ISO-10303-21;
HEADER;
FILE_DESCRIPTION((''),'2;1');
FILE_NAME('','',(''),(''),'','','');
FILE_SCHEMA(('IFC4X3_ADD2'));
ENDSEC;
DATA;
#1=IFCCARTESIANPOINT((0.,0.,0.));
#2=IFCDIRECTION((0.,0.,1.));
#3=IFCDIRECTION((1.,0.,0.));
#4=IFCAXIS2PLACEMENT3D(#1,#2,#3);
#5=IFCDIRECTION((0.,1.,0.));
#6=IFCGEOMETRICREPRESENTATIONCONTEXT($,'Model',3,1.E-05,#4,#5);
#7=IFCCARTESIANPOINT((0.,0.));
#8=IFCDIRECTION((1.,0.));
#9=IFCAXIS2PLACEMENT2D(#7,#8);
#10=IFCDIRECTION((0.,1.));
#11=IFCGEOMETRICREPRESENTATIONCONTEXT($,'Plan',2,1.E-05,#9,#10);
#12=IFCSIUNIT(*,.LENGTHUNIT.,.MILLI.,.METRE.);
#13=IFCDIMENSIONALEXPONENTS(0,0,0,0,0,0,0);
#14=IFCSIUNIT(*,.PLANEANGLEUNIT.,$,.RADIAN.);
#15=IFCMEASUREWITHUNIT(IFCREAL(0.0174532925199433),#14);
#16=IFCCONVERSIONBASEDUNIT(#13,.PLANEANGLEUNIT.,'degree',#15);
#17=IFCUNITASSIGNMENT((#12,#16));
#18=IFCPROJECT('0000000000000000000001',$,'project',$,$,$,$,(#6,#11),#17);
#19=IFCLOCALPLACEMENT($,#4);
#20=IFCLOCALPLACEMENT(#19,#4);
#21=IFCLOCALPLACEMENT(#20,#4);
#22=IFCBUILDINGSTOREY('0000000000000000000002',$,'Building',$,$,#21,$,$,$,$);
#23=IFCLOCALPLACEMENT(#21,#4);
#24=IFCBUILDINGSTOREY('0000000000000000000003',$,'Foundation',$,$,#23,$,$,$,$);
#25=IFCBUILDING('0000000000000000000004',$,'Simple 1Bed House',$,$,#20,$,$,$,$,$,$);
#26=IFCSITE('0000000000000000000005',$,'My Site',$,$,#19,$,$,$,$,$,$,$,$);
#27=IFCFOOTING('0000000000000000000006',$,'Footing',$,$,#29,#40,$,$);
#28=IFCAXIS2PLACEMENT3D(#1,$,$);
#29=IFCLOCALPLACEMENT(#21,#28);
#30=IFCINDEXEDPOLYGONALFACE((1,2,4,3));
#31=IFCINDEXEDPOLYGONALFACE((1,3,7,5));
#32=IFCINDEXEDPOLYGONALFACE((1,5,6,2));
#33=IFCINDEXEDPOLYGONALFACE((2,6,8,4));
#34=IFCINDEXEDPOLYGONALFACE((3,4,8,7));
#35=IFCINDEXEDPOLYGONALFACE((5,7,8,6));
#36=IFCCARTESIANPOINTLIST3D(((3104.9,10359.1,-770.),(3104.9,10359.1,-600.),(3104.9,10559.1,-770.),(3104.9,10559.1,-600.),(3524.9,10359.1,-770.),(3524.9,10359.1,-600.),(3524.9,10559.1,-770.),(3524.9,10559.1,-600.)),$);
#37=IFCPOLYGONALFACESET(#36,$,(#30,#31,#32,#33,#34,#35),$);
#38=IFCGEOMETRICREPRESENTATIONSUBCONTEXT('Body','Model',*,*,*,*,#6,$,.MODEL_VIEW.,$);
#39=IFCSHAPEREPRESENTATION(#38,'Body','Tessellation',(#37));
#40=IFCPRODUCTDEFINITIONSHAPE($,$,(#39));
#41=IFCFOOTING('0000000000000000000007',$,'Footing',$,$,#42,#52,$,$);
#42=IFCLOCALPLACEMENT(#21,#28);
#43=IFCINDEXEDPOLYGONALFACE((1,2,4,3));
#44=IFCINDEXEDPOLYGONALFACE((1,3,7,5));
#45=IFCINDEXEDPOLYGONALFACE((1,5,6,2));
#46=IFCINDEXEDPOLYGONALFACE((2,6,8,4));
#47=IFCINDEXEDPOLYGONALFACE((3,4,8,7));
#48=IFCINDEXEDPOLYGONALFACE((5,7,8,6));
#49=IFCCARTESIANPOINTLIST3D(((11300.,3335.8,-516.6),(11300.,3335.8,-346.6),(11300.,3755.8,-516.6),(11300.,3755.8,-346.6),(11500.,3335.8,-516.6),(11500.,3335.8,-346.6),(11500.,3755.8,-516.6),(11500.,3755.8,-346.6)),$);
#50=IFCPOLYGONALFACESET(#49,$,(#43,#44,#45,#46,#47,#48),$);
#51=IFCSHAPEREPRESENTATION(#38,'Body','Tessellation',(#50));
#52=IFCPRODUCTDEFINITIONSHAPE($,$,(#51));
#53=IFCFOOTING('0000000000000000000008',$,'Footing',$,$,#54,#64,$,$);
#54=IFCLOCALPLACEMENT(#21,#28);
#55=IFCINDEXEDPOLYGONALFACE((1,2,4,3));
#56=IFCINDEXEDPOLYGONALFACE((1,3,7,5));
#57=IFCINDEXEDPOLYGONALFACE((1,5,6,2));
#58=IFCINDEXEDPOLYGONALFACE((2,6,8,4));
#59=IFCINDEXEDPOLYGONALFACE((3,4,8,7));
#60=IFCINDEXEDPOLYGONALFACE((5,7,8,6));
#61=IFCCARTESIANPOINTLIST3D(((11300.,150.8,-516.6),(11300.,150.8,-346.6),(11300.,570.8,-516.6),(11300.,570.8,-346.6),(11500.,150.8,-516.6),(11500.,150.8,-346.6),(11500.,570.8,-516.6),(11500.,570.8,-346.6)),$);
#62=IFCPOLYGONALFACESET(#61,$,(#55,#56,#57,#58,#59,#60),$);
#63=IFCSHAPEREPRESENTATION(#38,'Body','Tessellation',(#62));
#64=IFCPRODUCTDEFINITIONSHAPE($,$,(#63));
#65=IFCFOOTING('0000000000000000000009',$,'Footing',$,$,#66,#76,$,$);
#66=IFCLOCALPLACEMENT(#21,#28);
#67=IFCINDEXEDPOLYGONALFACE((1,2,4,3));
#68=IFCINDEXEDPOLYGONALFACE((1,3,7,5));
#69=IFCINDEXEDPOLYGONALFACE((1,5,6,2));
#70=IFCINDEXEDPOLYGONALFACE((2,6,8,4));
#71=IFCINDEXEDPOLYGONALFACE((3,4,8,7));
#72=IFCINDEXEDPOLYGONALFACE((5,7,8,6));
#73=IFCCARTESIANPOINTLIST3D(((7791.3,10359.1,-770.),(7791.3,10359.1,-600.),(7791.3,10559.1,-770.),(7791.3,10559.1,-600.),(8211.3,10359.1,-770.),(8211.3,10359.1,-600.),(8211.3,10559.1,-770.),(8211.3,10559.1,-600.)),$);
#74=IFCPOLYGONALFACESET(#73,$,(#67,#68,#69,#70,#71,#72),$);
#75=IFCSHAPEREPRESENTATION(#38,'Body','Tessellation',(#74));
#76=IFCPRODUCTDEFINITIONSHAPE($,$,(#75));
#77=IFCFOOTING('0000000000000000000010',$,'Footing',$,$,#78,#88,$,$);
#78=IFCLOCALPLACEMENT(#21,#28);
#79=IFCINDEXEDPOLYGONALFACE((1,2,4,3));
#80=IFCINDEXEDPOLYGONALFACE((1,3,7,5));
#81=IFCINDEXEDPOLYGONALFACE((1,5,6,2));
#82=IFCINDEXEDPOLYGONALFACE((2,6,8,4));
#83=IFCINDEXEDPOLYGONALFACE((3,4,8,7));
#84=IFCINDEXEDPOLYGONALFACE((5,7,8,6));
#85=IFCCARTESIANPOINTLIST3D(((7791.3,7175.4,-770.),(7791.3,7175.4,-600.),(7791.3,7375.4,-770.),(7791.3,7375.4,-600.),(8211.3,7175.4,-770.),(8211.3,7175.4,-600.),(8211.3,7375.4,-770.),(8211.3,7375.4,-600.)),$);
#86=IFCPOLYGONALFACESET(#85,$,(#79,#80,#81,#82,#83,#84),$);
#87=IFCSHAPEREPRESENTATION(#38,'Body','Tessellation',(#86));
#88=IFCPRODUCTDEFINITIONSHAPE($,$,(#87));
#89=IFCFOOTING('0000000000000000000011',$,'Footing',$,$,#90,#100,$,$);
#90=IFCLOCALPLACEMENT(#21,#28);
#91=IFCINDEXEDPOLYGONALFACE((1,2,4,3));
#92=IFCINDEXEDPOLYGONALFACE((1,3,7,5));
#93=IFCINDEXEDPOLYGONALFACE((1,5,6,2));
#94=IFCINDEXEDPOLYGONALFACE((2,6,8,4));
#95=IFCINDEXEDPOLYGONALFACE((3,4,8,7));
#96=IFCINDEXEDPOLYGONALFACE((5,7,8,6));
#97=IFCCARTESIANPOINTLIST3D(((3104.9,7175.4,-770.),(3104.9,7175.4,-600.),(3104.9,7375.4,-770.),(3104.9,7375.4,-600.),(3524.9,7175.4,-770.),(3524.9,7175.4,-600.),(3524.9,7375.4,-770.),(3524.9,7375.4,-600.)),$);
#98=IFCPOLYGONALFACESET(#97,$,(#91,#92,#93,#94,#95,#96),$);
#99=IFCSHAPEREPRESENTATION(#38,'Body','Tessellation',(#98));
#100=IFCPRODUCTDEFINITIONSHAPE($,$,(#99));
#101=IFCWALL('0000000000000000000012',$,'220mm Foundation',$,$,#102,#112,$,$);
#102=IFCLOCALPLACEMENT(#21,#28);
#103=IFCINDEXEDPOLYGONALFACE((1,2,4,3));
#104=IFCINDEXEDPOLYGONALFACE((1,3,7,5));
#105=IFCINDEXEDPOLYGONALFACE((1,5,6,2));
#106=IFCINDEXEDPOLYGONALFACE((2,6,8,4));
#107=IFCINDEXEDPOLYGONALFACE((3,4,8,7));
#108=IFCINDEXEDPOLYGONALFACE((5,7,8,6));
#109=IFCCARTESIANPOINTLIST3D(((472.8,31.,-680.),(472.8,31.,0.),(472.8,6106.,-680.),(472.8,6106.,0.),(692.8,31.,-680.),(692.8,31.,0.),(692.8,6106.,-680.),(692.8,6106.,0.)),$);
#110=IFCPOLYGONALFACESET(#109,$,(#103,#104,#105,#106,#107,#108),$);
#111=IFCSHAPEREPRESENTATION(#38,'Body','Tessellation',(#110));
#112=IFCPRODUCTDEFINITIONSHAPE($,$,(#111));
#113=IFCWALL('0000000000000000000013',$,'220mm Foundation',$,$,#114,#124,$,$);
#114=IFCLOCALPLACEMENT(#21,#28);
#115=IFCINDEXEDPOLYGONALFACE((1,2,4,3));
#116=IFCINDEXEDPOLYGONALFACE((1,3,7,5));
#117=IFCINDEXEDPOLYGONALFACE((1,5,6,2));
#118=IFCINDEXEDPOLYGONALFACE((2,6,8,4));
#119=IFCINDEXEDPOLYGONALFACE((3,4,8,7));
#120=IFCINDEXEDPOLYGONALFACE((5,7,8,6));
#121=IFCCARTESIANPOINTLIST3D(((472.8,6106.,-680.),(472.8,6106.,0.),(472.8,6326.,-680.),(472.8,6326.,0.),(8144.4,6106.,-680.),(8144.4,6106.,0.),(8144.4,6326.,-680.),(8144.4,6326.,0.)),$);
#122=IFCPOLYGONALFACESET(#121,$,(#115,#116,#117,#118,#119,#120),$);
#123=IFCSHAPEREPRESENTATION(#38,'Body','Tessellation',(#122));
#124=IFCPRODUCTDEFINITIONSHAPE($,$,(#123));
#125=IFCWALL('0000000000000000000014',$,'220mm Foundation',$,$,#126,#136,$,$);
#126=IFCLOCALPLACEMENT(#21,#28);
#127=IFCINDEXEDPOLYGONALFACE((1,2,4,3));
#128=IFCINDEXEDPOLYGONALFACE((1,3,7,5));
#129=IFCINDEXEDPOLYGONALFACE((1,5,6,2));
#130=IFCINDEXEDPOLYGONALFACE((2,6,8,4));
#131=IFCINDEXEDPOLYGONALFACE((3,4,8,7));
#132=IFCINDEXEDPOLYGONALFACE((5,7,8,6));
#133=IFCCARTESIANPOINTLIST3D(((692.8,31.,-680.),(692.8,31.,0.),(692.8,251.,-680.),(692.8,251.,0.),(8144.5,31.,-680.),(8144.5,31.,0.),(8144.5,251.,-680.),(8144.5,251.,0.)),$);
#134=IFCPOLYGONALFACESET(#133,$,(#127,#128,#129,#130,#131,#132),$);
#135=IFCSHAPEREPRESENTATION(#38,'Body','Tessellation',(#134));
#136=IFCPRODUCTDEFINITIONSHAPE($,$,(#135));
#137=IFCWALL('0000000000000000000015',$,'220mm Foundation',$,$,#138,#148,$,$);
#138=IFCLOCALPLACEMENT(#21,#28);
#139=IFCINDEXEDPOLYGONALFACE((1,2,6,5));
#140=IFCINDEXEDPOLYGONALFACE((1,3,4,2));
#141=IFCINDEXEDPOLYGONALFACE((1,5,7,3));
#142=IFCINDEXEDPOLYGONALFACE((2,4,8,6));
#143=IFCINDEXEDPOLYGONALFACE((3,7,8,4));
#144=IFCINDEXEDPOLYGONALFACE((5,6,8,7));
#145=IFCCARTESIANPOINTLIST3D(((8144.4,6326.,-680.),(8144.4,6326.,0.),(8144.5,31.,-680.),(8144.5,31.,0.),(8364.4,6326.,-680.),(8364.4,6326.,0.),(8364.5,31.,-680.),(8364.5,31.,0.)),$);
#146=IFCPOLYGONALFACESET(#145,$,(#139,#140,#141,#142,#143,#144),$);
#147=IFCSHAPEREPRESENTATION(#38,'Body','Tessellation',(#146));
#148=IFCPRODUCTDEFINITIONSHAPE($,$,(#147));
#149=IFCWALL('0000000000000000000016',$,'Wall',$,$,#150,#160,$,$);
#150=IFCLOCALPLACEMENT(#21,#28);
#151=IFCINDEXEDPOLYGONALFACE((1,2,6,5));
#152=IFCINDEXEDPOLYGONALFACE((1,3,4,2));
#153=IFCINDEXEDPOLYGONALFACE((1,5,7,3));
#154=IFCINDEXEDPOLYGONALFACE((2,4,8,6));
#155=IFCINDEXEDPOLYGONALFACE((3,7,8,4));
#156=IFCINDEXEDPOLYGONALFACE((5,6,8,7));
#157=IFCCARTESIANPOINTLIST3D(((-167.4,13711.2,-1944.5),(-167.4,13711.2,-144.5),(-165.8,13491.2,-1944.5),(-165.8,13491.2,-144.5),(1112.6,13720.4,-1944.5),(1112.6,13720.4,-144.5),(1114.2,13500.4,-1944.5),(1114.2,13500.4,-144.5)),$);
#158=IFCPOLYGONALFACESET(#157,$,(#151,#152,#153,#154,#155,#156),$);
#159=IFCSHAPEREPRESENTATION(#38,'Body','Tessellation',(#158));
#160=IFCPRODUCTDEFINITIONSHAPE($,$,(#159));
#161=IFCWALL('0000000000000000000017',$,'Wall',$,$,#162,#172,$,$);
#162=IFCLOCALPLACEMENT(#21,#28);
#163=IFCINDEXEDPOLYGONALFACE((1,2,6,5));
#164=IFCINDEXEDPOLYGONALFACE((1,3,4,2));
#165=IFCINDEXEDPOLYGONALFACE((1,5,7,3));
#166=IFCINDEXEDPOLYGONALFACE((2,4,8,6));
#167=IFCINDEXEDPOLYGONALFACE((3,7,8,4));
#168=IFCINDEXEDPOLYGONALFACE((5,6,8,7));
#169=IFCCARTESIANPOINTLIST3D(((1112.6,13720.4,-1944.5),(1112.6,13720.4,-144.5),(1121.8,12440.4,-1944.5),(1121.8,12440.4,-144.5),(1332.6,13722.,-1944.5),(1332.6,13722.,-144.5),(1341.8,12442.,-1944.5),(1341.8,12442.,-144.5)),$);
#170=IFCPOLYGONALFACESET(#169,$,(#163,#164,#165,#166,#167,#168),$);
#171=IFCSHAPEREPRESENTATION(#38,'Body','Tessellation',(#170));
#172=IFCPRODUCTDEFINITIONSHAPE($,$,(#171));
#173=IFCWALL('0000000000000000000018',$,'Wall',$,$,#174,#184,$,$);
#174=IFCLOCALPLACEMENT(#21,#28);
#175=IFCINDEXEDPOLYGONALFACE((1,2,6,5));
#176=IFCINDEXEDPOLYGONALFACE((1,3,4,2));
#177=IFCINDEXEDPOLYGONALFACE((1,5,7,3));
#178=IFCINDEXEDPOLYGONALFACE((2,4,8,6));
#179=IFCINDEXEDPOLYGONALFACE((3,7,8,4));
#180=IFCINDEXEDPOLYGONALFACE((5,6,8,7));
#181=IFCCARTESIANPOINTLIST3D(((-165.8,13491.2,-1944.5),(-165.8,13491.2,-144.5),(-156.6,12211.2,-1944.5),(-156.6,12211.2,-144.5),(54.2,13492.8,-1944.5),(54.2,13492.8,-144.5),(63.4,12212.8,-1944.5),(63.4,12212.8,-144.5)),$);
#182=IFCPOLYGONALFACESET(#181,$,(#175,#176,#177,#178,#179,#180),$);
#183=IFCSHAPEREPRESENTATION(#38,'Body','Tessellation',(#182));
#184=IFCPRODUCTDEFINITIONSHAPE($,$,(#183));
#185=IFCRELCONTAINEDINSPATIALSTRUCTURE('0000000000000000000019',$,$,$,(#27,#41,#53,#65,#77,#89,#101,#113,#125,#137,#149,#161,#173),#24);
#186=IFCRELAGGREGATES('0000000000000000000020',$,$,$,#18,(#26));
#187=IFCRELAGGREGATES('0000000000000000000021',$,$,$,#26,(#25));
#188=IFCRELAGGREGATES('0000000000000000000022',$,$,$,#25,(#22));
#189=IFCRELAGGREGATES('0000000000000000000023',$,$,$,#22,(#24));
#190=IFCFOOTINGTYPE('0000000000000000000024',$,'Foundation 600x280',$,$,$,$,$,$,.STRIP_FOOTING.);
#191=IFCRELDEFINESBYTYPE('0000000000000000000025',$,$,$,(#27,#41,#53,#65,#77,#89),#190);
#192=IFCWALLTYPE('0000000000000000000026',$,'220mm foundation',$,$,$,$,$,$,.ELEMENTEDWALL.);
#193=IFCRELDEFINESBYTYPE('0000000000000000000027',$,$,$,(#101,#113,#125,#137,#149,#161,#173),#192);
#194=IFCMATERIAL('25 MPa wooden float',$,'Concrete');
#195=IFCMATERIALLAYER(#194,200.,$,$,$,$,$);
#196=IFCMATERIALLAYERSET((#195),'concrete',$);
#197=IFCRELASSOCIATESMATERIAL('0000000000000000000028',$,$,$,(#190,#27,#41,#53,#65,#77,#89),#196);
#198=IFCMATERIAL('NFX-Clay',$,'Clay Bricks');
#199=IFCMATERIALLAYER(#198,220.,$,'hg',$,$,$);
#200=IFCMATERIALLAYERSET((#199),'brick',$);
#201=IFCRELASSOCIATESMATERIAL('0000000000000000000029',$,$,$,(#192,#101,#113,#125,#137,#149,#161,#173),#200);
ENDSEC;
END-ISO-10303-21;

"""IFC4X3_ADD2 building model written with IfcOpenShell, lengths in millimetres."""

from ifc_helpers import new_model, entity, si_unit, converted_unit, direction, frame, origin_with_axes, origin_2d_with_axis, place, context, subcontext, project, spatial, indexed_curve, outline, extrude, material, layer, layer_set, layer_usage, type_object, element, save


model = new_model("IFC4X3_ADD2")

# Units and contexts
model_context = context("Model", 3, precision=1e-05, world=origin_with_axes(), true_north=direction((0.0, 1.0, 0.0)))
plan_context = context("Plan", 2, precision=1e-05, world=origin_2d_with_axis(), true_north=direction((0.0, 1.0)))
body_context = subcontext(model_context, "Body", "Model", "MODEL_VIEW")
ifc_project = project(units=[si_unit("LENGTHUNIT", "METRE", prefix="MILLI"), converted_unit("PLANEANGLEUNIT", "degree", entity("IfcReal", 0.0174532925199433), si_unit("PLANEANGLEUNIT", "RADIAN"), dimensions=[0, 0, 0, 0, 0, 0, 0])], contexts=[model_context, plan_context])

# Site, building, storeys
site_placement = place(None, origin_with_axes())
site = spatial("IfcSite", under=ifc_project, at=site_placement, Name="My Site")
building_placement = place(site_placement, origin_with_axes())
building = spatial("IfcBuilding", under=site, at=building_placement, Name="Simple 1Bed House")
storey_1_placement = place(building_placement, origin_with_axes())
storey_1 = spatial("IfcBuildingStorey", under=building, at=storey_1_placement, Name="Building")
storey_2_placement = place(storey_1_placement, origin_with_axes())
storey_2 = spatial("IfcBuildingStorey", under=storey_1, at=storey_2_placement, Name="Foundation")

# Footings
ifc_material_1 = material(Name="25 MPa wooden float", Category="Concrete")
ifc_layer_1 = layer(ifc_material_1, 200.0)
ifc_layer_set_1 = layer_set([ifc_layer_1], Name="concrete")
footing_type = type_object("IfcFootingType", Name="Foundation 600x280", PredefinedType="STRIP_FOOTING", material=ifc_layer_set_1)
ifc_layer_usage_1 = layer_usage(ifc_layer_set_1, "AXIS2", "POSITIVE", 0.0)
footing_1_placement = place(storey_2_placement, frame((3104.9, 10359.1, -770.0), z_axis=(0.0, 0.0, 1.0), x_axis=(1.0, 0.0, 0.0)))
element("IfcFooting", 1, at=footing_1_placement, inside=storey_2, type_object=footing_type, material=ifc_layer_usage_1, Name="Footing", context=body_context, shape_type="SweptSolid", body=[
    extrude(outline(indexed_curve([(0.0, 0.0), (0.0, 200.0), (420.0, 200.0), (420.0, 0.0), (0.0, 0.0)], self_intersect=False)), origin_with_axes(), (0.0, 0.0, 1.0), 170.0),
])
ifc_layer_usage_2 = layer_usage(ifc_layer_set_1, "AXIS2", "POSITIVE", 0.0)
footing_2_placement = place(storey_2_placement, frame((11500.0, 3335.8, -516.6), z_axis=(0.0, 0.0, 1.0), x_axis=(0.0, 1.0, 0.0)))
element("IfcFooting", 2, at=footing_2_placement, inside=storey_2, type_object=footing_type, material=ifc_layer_usage_2, Name="Footing", context=body_context, shape_type="SweptSolid", body=[
    extrude(outline(indexed_curve([(0.0, 0.0), (0.0, 200.0), (420.0, 200.0), (420.0, 0.0), (0.0, 0.0)], self_intersect=False)), origin_with_axes(), (0.0, 0.0, 1.0), 170.0),
])
ifc_layer_usage_3 = layer_usage(ifc_layer_set_1, "AXIS2", "POSITIVE", 0.0)
footing_3_placement = place(storey_2_placement, frame((11500.0, 150.8, -516.6), z_axis=(0.0, 0.0, 1.0), x_axis=(0.0, 1.0, 0.0)))
element("IfcFooting", 3, at=footing_3_placement, inside=storey_2, type_object=footing_type, material=ifc_layer_usage_3, Name="Footing", context=body_context, shape_type="SweptSolid", body=[
    extrude(outline(indexed_curve([(0.0, 0.0), (0.0, 200.0), (420.0, 200.0), (420.0, 0.0), (0.0, 0.0)], self_intersect=False)), origin_with_axes(), (0.0, 0.0, 1.0), 170.0),
])
ifc_layer_usage_4 = layer_usage(ifc_layer_set_1, "AXIS2", "POSITIVE", 0.0)
footing_4_placement = place(storey_2_placement, frame((7791.3, 10359.1, -770.0), z_axis=(0.0, 0.0, 1.0), x_axis=(1.0, 0.0, 0.0)))
element("IfcFooting", 4, at=footing_4_placement, inside=storey_2, type_object=footing_type, material=ifc_layer_usage_4, Name="Footing", context=body_context, shape_type="SweptSolid", body=[
    extrude(outline(indexed_curve([(0.0, 0.0), (0.0, 200.0), (420.0, 200.0), (420.0, 0.0), (0.0, 0.0)], self_intersect=False)), origin_with_axes(), (0.0, 0.0, 1.0), 170.0),
])
ifc_layer_usage_5 = layer_usage(ifc_layer_set_1, "AXIS2", "POSITIVE", 0.0)
footing_5_placement = place(storey_2_placement, frame((7791.3, 7175.4, -770.0), z_axis=(0.0, 0.0, 1.0), x_axis=(1.0, 0.0, 0.0)))
element("IfcFooting", 5, at=footing_5_placement, inside=storey_2, type_object=footing_type, material=ifc_layer_usage_5, Name="Footing", context=body_context, shape_type="SweptSolid", body=[
    extrude(outline(indexed_curve([(0.0, 0.0), (0.0, 200.0), (420.0, 200.0), (420.0, 0.0), (0.0, 0.0)], self_intersect=False)), origin_with_axes(), (0.0, 0.0, 1.0), 170.0),
])
ifc_layer_usage_6 = layer_usage(ifc_layer_set_1, "AXIS2", "POSITIVE", 0.0)
footing_6_placement = place(storey_2_placement, frame((3104.9, 7175.4, -770.0), z_axis=(0.0, 0.0, 1.0), x_axis=(1.0, 0.0, 0.0)))
element("IfcFooting", 6, at=footing_6_placement, inside=storey_2, type_object=footing_type, material=ifc_layer_usage_6, Name="Footing", context=body_context, shape_type="SweptSolid", body=[
    extrude(outline(indexed_curve([(0.0, 0.0), (0.0, 200.0), (420.0, 200.0), (420.0, 0.0), (0.0, 0.0)], self_intersect=False)), origin_with_axes(), (0.0, 0.0, 1.0), 170.0),
])

# Walls
ifc_material_2 = material(Name="NFX-Clay", Category="Clay Bricks")
ifc_layer_2 = layer(ifc_material_2, 220.0, Name="hg")
ifc_layer_set_2 = layer_set([ifc_layer_2], Name="brick")
ifc_layer_usage_7 = layer_usage(ifc_layer_set_2, "AXIS2", "POSITIVE", 0.0)
wall_type = type_object("IfcWallType", Name="220mm foundation", PredefinedType="ELEMENTEDWALL", material=ifc_layer_set_2)
wall_1_placement = place(storey_2_placement, frame((472.8, 6106.0, -680.0), z_axis=(0.0, 0.0, 1.0), x_axis=(0.000002, -1.0, 0.0)))
element("IfcWall", 7, at=wall_1_placement, inside=storey_2, type_object=wall_type, material=ifc_layer_usage_7, Name="220mm Foundation", context=body_context, shape_type="SweptSolid", body=[
    extrude(outline(indexed_curve([(0.0, 0.0), (0.0, 220.0), (6075.0, 220.0), (6075.0, 0.0), (0.0, 0.0)], self_intersect=False)), origin_with_axes(), (0.0, 0.0, 1.0), 680.0),
])
ifc_layer_usage_8 = layer_usage(ifc_layer_set_2, "AXIS2", "POSITIVE", 0.0)
wall_2_placement = place(storey_2_placement, frame((472.8, 6106.0, -680.0), z_axis=(0.0, 0.0, 1.0), x_axis=(1.0, 0.000001, 0.0)))
element("IfcWall", 8, at=wall_2_placement, inside=storey_2, type_object=wall_type, material=ifc_layer_usage_8, Name="220mm Foundation", context=body_context, shape_type="SweptSolid", body=[
    extrude(outline(indexed_curve([(0.0, 0.0), (0.0, 220.0), (7671.6, 220.0), (7671.6, 0.0), (0.0, 0.0)], self_intersect=False)), origin_with_axes(), (0.0, 0.0, 1.0), 680.0),
])
ifc_layer_usage_9 = layer_usage(ifc_layer_set_2, "AXIS2", "POSITIVE", 0.0)
wall_3_placement = place(storey_2_placement, frame((692.8, 31.0, -680.0), z_axis=(0.0, 0.0, 1.0), x_axis=(1.0, 0.000001, 0.0)))
element("IfcWall", 9, at=wall_3_placement, inside=storey_2, type_object=wall_type, material=ifc_layer_usage_9, Name="220mm Foundation", context=body_context, shape_type="SweptSolid", body=[
    extrude(outline(indexed_curve([(0.0, 0.0), (0.0, 220.0), (7451.6, 220.0), (7451.6, 0.0), (0.0, 0.0)], self_intersect=False)), origin_with_axes(), (0.0, 0.0, 1.0), 680.0),
])
ifc_layer_usage_10 = layer_usage(ifc_layer_set_2, "AXIS2", "POSITIVE", 0.0)
wall_4_placement = place(storey_2_placement, frame((8144.4, 6326.0, -680.0), z_axis=(0.0, 0.0, 1.0), x_axis=(0.000002, -1.0, 0.0)))
element("IfcWall", 10, at=wall_4_placement, inside=storey_2, type_object=wall_type, material=ifc_layer_usage_10, Name="220mm Foundation", context=body_context, shape_type="SweptSolid", body=[
    extrude(outline(indexed_curve([(0.0, 0.0), (0.0, 220.0), (6295.0, 220.0), (6295.0, 0.0), (0.0, 0.0)], self_intersect=False)), origin_with_axes(), (0.0, 0.0, 1.0), 680.0),
])
ifc_layer_usage_11 = layer_usage(ifc_layer_set_2, "AXIS2", "POSITIVE", 0.0)
wall_5_placement = place(storey_2_placement, frame((1112.6, 13720.4, -1944.5), z_axis=(0.0, 0.0, 1.0), x_axis=(-0.999974, -0.007176, 0.0)))
element("IfcWall", 11, at=wall_5_placement, inside=storey_2, type_object=wall_type, material=ifc_layer_usage_11, Name="Wall", context=body_context, shape_type="SweptSolid", body=[
    extrude(outline(indexed_curve([(0.0, 0.0), (0.0, 220.0), (1280.0, 220.0), (1280.0, 0.0), (0.0, 0.0)], self_intersect=False)), origin_with_axes(), (0.0, 0.0, 1.0), 1800.0),
])
ifc_layer_usage_12 = layer_usage(ifc_layer_set_2, "AXIS2", "POSITIVE", 0.0)
wall_6_placement = place(storey_2_placement, frame((1341.8, 12442.0, -1944.5), z_axis=(0.0, 0.0, 1.0), x_axis=(-0.007176, 0.999974, 0.0)))
element("IfcWall", 12, at=wall_6_placement, inside=storey_2, type_object=wall_type, material=ifc_layer_usage_12, Name="Wall", context=body_context, shape_type="SweptSolid", body=[
    extrude(outline(indexed_curve([(0.0, 0.0), (0.0, 220.0), (1280.0, 220.0), (1280.0, 0.0), (0.0, 0.0)], self_intersect=False)), origin_with_axes(), (0.0, 0.0, 1.0), 1800.0),
])
ifc_layer_usage_13 = layer_usage(ifc_layer_set_2, "AXIS2", "POSITIVE", 0.0)
wall_7_placement = place(storey_2_placement, frame((-165.8, 13491.2, -1944.5), z_axis=(0.0, 0.0, 1.0), x_axis=(0.007176, -0.999974, 0.0)))
element("IfcWall", 13, at=wall_7_placement, inside=storey_2, type_object=wall_type, material=ifc_layer_usage_13, Name="Wall", context=body_context, shape_type="SweptSolid", body=[
    extrude(outline(indexed_curve([(0.0, 0.0), (0.0, 220.0), (1280.0, 220.0), (1280.0, 0.0), (0.0, 0.0)], self_intersect=False)), origin_with_axes(), (0.0, 0.0, 1.0), 1800.0),
])

save(model, "model.ifc")
